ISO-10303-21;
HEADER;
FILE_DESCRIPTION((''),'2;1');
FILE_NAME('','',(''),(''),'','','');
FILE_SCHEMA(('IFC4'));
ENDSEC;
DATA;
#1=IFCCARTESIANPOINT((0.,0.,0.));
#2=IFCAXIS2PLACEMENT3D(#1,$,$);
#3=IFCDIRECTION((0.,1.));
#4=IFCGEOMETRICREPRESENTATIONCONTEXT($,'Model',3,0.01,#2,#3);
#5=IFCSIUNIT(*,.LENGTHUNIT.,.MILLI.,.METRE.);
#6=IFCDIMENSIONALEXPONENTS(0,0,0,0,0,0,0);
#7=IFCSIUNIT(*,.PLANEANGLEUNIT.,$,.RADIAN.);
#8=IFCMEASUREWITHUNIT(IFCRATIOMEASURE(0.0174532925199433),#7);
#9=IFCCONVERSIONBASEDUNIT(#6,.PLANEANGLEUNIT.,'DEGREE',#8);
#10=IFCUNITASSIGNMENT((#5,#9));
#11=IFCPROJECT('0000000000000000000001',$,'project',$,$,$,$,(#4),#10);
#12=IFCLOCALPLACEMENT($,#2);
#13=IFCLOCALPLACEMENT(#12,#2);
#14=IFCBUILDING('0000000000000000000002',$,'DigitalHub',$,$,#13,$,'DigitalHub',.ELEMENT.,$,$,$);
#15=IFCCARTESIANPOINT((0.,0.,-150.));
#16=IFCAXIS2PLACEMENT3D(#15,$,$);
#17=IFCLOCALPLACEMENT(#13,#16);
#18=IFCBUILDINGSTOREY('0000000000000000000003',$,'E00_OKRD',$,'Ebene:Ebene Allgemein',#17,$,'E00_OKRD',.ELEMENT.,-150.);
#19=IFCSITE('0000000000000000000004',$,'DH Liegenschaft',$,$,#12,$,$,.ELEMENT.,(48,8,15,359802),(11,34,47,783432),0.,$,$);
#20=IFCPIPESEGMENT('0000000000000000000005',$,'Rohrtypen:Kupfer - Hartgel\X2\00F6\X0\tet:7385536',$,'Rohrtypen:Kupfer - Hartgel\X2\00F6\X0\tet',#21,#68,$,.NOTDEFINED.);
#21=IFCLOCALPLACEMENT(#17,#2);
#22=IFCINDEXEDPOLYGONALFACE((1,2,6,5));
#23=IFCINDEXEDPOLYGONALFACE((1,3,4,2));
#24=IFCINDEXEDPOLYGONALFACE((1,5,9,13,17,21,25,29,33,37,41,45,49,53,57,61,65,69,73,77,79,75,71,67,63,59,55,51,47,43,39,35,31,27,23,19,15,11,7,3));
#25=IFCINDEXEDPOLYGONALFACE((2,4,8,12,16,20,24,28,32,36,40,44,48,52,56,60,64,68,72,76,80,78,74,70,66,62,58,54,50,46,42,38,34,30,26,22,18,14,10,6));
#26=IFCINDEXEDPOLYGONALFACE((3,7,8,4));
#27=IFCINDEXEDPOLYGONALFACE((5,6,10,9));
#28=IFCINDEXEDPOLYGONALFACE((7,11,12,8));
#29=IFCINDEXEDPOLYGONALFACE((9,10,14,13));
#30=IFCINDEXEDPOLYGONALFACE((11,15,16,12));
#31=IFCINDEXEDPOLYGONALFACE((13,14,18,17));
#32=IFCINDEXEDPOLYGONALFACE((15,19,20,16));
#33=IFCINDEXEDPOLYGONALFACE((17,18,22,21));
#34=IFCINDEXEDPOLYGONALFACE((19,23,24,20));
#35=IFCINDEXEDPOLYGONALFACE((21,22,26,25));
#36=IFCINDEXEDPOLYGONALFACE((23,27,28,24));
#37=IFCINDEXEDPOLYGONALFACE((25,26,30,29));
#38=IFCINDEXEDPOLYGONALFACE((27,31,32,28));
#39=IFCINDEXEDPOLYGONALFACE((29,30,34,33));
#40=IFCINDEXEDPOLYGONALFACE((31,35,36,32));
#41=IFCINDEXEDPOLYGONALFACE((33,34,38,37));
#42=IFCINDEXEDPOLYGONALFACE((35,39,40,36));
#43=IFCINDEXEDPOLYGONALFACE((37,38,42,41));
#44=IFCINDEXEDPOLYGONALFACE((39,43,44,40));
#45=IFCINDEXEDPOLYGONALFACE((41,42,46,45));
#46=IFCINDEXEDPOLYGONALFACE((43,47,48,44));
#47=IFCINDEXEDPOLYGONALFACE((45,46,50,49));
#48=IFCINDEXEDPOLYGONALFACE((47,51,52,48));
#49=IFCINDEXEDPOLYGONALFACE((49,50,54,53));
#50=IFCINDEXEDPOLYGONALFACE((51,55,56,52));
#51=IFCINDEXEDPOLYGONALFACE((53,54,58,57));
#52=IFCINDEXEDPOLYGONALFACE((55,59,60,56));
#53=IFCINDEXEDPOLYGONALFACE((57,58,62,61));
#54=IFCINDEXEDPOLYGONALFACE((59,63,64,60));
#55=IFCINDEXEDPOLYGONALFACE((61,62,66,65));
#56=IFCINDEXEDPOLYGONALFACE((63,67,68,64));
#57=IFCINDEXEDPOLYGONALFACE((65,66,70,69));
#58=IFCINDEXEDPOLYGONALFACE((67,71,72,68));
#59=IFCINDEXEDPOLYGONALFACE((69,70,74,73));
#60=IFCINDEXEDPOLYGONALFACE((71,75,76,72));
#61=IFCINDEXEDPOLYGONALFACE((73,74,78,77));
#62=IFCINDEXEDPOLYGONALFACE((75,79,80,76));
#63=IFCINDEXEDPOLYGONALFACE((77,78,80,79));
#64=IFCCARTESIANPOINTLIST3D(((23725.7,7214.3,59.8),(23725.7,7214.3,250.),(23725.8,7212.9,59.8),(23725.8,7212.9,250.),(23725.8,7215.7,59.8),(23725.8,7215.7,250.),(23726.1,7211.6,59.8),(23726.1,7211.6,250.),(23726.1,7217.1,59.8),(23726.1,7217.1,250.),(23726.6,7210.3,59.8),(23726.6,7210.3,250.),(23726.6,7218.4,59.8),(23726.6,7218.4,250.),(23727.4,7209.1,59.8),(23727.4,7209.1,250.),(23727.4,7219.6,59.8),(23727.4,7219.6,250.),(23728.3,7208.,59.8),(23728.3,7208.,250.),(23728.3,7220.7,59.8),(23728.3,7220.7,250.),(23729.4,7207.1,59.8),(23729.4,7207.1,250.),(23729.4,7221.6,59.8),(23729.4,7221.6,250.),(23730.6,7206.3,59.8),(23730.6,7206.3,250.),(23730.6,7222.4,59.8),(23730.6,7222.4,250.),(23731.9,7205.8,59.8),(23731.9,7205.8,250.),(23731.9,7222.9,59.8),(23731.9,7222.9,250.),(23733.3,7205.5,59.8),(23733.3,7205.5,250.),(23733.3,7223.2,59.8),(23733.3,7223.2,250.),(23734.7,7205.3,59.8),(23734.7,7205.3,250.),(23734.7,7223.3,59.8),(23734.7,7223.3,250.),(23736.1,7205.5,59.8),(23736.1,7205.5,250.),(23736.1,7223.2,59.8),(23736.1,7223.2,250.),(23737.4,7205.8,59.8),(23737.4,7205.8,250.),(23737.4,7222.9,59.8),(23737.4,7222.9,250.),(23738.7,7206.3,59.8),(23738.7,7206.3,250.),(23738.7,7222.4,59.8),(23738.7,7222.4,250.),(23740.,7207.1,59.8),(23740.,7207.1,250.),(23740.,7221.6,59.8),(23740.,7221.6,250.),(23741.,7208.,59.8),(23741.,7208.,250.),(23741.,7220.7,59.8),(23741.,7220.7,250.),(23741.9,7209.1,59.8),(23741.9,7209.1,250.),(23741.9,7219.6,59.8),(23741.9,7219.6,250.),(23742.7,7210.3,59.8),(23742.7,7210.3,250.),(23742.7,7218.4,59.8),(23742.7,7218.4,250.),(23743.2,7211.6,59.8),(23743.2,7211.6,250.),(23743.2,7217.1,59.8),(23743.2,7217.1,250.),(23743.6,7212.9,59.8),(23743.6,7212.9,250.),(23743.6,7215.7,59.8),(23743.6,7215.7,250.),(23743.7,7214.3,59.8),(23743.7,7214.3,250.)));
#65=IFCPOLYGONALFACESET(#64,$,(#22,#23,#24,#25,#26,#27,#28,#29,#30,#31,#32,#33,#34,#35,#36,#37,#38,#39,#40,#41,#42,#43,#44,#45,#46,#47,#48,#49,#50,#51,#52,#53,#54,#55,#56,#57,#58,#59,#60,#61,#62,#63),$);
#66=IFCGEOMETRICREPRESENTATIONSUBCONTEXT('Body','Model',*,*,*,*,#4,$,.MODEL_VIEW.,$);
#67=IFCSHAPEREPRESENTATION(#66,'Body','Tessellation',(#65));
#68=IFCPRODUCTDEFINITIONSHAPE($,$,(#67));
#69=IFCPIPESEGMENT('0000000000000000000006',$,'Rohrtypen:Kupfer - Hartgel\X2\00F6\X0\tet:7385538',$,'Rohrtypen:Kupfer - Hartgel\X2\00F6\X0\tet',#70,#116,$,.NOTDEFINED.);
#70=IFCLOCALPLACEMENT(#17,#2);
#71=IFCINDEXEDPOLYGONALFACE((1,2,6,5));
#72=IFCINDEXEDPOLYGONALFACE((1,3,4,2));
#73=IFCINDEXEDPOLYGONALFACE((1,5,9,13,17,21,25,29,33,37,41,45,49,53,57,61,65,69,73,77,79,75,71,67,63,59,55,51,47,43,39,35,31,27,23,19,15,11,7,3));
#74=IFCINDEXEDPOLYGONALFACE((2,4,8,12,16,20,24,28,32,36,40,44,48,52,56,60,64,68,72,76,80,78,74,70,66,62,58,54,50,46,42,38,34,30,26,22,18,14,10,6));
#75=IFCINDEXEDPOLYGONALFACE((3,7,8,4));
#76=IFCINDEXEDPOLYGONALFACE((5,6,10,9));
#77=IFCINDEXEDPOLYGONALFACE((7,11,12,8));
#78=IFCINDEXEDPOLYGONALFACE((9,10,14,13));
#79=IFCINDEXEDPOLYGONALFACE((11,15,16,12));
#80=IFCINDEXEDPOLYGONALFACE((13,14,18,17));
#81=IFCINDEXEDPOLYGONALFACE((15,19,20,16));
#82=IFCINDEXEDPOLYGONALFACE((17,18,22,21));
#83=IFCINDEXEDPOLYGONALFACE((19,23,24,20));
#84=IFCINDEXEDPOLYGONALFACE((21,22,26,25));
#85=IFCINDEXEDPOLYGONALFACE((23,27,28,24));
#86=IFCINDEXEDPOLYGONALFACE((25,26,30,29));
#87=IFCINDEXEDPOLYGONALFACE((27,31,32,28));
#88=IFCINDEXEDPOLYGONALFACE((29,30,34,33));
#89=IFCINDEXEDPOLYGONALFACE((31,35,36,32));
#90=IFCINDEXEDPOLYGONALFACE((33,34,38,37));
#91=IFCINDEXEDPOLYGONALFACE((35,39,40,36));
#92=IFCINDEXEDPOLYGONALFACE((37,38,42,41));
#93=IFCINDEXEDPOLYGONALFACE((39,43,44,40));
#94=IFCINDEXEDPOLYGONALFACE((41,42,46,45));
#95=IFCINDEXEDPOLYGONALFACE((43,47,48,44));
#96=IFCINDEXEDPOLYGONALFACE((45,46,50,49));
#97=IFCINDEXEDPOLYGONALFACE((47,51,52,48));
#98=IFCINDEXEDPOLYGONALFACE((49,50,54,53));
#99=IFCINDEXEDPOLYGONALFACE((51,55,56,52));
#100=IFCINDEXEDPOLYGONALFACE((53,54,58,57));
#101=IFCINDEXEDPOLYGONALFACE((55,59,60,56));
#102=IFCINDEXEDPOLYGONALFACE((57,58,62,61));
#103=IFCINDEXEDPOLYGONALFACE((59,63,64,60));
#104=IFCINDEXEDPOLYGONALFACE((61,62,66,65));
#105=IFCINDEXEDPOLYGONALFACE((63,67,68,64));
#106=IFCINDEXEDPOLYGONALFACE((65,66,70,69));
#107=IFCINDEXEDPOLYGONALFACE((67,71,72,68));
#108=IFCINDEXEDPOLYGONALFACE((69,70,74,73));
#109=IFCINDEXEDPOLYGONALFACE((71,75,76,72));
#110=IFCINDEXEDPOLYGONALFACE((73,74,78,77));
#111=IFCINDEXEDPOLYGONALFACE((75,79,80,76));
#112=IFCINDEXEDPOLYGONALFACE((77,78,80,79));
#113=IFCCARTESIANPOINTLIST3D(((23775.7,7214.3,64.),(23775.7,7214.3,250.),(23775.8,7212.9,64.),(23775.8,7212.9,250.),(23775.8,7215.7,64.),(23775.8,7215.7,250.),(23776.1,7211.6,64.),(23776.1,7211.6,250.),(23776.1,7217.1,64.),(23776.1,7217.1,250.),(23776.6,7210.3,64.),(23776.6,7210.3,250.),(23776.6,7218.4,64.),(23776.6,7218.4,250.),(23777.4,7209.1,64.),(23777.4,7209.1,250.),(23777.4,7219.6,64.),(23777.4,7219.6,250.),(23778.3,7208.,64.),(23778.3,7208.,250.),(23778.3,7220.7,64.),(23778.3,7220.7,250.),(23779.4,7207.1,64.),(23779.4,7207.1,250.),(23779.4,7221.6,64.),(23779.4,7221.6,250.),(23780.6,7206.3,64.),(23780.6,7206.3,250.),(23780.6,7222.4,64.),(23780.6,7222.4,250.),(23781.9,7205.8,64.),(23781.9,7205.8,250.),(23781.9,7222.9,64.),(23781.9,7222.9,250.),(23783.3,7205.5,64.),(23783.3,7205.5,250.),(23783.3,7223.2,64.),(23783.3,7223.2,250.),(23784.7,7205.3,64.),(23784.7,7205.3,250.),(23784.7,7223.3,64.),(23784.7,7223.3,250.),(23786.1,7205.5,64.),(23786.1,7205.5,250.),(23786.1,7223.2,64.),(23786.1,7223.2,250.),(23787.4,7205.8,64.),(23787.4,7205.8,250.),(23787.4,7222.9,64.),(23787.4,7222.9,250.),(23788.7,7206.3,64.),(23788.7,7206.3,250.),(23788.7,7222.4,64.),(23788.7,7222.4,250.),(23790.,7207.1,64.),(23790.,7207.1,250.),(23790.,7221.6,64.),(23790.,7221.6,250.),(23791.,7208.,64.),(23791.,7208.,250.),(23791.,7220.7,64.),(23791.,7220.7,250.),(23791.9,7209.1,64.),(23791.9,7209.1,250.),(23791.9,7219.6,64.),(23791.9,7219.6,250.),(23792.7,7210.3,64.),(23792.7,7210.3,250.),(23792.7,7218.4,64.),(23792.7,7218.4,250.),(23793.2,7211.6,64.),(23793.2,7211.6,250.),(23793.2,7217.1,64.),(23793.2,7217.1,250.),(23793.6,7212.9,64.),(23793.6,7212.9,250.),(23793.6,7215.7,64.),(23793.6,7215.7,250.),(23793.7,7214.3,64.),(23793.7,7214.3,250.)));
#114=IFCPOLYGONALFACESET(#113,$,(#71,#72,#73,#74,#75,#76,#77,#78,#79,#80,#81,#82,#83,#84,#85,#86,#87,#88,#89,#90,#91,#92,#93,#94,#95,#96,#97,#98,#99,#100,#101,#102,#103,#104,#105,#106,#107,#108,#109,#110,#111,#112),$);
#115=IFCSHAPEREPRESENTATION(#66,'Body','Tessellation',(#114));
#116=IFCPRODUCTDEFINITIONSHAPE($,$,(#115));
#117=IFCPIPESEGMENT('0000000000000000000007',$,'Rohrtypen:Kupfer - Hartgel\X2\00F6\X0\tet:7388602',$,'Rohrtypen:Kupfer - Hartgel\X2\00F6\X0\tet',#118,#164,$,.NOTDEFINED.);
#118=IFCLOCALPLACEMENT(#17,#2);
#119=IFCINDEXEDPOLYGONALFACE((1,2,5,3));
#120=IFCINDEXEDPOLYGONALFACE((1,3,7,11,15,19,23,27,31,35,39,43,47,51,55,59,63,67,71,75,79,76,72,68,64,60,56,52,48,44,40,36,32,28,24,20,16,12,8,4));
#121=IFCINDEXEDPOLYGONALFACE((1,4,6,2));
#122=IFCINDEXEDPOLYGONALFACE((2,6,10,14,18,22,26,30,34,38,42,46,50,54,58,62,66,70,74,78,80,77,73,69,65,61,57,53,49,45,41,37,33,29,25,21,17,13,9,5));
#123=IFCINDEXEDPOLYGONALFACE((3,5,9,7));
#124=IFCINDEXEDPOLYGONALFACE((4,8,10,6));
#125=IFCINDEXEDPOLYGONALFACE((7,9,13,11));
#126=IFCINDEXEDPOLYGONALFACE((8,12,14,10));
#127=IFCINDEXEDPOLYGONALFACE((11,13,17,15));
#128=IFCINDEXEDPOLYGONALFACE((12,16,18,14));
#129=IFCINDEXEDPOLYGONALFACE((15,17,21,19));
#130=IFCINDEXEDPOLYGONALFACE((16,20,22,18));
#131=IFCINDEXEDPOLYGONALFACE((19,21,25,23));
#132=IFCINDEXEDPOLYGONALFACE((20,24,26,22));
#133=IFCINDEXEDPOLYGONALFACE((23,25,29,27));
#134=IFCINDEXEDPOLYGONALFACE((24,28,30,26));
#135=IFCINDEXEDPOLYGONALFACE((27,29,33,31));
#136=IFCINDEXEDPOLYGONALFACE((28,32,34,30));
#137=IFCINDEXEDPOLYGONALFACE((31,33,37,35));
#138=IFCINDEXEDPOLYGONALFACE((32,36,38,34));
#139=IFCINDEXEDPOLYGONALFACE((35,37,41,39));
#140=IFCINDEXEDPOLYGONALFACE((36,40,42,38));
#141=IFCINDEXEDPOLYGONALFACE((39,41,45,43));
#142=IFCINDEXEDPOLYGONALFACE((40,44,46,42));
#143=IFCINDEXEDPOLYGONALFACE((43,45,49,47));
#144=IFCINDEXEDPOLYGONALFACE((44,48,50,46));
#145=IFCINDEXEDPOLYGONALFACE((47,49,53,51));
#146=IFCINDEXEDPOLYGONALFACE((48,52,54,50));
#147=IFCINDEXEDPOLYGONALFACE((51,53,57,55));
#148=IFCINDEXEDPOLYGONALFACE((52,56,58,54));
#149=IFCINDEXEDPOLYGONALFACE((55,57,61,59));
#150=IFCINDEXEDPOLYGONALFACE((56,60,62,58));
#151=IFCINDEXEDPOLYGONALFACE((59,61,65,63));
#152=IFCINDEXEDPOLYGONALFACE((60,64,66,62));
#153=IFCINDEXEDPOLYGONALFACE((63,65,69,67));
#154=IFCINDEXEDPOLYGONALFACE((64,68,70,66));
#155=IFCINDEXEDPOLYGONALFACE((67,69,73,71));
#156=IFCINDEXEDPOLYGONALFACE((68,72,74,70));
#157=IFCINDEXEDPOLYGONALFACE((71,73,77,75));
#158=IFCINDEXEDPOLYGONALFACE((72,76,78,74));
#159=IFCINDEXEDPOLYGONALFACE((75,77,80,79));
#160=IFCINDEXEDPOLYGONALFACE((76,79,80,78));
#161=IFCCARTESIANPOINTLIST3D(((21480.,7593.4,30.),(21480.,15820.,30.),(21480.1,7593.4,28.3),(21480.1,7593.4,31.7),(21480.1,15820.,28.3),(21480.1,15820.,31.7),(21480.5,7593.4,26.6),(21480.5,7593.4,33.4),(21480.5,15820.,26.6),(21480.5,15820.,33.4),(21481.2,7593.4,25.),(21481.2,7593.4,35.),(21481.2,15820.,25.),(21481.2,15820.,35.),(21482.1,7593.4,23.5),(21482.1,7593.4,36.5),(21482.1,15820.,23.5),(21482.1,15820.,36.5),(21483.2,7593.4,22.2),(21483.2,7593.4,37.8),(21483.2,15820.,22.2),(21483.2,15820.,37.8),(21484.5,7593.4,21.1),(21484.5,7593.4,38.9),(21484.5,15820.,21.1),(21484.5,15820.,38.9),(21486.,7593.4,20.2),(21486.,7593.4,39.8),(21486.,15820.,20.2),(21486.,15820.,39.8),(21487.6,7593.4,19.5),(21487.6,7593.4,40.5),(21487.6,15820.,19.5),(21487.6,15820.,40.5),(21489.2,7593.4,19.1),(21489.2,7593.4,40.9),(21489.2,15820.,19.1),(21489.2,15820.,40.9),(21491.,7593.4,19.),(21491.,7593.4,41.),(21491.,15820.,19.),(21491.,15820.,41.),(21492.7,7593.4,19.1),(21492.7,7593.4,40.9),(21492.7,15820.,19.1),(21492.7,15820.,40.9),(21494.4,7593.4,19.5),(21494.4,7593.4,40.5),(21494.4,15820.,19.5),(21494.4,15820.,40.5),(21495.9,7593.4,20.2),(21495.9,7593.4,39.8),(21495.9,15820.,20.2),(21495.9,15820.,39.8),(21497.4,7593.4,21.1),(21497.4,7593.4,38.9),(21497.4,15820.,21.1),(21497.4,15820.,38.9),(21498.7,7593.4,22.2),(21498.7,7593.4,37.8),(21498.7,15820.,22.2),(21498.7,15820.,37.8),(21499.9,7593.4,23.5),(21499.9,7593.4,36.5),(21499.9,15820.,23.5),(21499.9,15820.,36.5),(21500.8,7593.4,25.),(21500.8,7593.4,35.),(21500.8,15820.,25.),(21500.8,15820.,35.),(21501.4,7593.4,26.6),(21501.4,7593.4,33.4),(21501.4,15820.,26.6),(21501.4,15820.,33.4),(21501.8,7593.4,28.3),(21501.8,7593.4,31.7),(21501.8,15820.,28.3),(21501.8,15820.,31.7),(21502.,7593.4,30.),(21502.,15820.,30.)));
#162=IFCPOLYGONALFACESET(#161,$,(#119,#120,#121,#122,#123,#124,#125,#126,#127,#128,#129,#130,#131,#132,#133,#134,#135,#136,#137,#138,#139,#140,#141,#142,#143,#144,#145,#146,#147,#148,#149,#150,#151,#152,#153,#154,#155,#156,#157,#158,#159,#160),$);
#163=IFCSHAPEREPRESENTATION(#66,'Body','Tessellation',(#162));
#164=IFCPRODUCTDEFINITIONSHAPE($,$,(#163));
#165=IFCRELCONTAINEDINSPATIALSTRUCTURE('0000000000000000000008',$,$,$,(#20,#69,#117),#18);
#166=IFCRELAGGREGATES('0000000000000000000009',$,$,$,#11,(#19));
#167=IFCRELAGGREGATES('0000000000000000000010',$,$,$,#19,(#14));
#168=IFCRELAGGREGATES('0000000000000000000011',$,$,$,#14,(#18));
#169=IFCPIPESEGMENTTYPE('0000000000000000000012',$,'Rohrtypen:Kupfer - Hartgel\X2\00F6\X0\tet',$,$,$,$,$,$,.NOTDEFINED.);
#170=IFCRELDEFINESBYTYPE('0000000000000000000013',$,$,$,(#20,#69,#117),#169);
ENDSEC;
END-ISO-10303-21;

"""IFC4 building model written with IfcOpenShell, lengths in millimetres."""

from ifc_helpers import new_model, entity, si_unit, converted_unit, direction, frame, origin, place, context, subcontext, project, spatial, indexed_curve, outline, extrude, type_object, element, save


model = new_model("IFC4")

# Units and contexts
model_context = context("Model", 3, precision=0.01, world=origin(), true_north=direction((0.0, 1.0)))
body_context = subcontext(model_context, "Body", "Model", "MODEL_VIEW")
ifc_project = project(units=[si_unit("LENGTHUNIT", "METRE", prefix="MILLI"), converted_unit("PLANEANGLEUNIT", "DEGREE", entity("IfcRatioMeasure", 0.0174532925199433), si_unit("PLANEANGLEUNIT", "RADIAN"), dimensions=[0, 0, 0, 0, 0, 0, 0])], contexts=[model_context])

# Site, building, storey
site_placement = place(None, origin())
site = spatial("IfcSite", under=ifc_project, at=site_placement, Name="DH Liegenschaft", CompositionType="ELEMENT", RefLatitude=(48, 8, 15, 359802), RefLongitude=(11, 34, 47, 783432), RefElevation=0.0)
building_placement = place(site_placement, origin())
building = spatial("IfcBuilding", under=site, at=building_placement, Name="DigitalHub", LongName="DigitalHub", CompositionType="ELEMENT")
storey_placement = place(building_placement, frame((0.0, 0.0, -150.0)))
storey = spatial("IfcBuildingStorey", under=building, at=storey_placement, Name="E00_OKRD", ObjectType="Ebene:Ebene Allgemein", LongName="E00_OKRD", CompositionType="ELEMENT", Elevation=-150.0)

# Pipe segments
pipe_segment_type = type_object("IfcPipeSegmentType", Name="Rohrtypen:Kupfer - Hartgelötet", PredefinedType="NOTDEFINED")
pipe_segment_1_placement = place(storey_placement, frame((23724.1, 7203.7, 59.8)))
element("IfcPipeSegment", 1, at=pipe_segment_1_placement, inside=storey, type_object=pipe_segment_type, Name="Rohrtypen:Kupfer - Hartgelötet:7385536", ObjectType="Rohrtypen:Kupfer - Hartgelötet", PredefinedType="NOTDEFINED", context=body_context, shape_type="SweptSolid", body=[
    extrude(outline(indexed_curve([(9.0, 0.0), (8.9, 1.4), (8.6, 2.8), (8.0, 4.1), (7.3, 5.3), (6.4, 6.4), (5.3, 7.3), (4.1, 8.0), (2.8, 8.6), (1.4, 8.9), (0.0, 9.0), (-1.4, 8.9), (-2.8, 8.6), (-4.1, 8.0), (-5.3, 7.3), (-6.4, 6.4), (-7.3, 5.3), (-8.0, 4.1), (-8.6, 2.8), (-8.9, 1.4), (-9.0, 0.0), (-8.9, -1.4), (-8.6, -2.8), (-8.0, -4.1), (-7.3, -5.3), (-6.4, -6.4), (-5.3, -7.3), (-4.1, -8.0), (-2.8, -8.6), (-1.4, -8.9), (0.0, -9.0), (1.4, -8.9), (2.8, -8.6), (4.1, -8.0), (5.3, -7.3), (6.4, -6.4), (7.3, -5.3), (8.0, -4.1), (8.6, -2.8), (8.9, -1.4), (9.0, 0.0)], self_intersect=False)), frame((10.6, 10.6, 0.0)), (0.0, 0.0, 1.0), 190.2),
])
pipe_segment_2_placement = place(storey_placement, frame((23774.1, 7203.7, 64.0)))
element("IfcPipeSegment", 2, at=pipe_segment_2_placement, inside=storey, type_object=pipe_segment_type, Name="Rohrtypen:Kupfer - Hartgelötet:7385538", ObjectType="Rohrtypen:Kupfer - Hartgelötet", PredefinedType="NOTDEFINED", context=body_context, shape_type="SweptSolid", body=[
    extrude(outline(indexed_curve([(9.0, 0.0), (8.9, 1.4), (8.6, 2.8), (8.0, 4.1), (7.3, 5.3), (6.4, 6.4), (5.3, 7.3), (4.1, 8.0), (2.8, 8.6), (1.4, 8.9), (0.0, 9.0), (-1.4, 8.9), (-2.8, 8.6), (-4.1, 8.0), (-5.3, 7.3), (-6.4, 6.4), (-7.3, 5.3), (-8.0, 4.1), (-8.6, 2.8), (-8.9, 1.4), (-9.0, 0.0), (-8.9, -1.4), (-8.6, -2.8), (-8.0, -4.1), (-7.3, -5.3), (-6.4, -6.4), (-5.3, -7.3), (-4.1, -8.0), (-2.8, -8.6), (-1.4, -8.9), (0.0, -9.0), (1.4, -8.9), (2.8, -8.6), (4.1, -8.0), (5.3, -7.3), (6.4, -6.4), (7.3, -5.3), (8.0, -4.1), (8.6, -2.8), (8.9, -1.4), (9.0, 0.0)], self_intersect=False)), frame((10.6, 10.6, 0.0)), (0.0, 0.0, 1.0), 186.0),
])
pipe_segment_3_placement = place(storey_placement, frame((21478.4, 7593.4, 17.4)))
element("IfcPipeSegment", 3, at=pipe_segment_3_placement, inside=storey, type_object=pipe_segment_type, Name="Rohrtypen:Kupfer - Hartgelötet:7388602", ObjectType="Rohrtypen:Kupfer - Hartgelötet", PredefinedType="NOTDEFINED", context=body_context, shape_type="SweptSolid", body=[
    extrude(outline(indexed_curve([(11.0, 0.0), (10.9, 1.7), (10.5, 3.4), (9.8, 5.0), (8.9, 6.5), (7.8, 7.8), (6.5, 8.9), (5.0, 9.8), (3.4, 10.5), (1.7, 10.9), (0.0, 11.0), (-1.7, 10.9), (-3.4, 10.5), (-5.0, 9.8), (-6.5, 8.9), (-7.8, 7.8), (-8.9, 6.5), (-9.8, 5.0), (-10.5, 3.4), (-10.9, 1.7), (-11.0, 0.0), (-10.9, -1.7), (-10.5, -3.4), (-9.8, -5.0), (-8.9, -6.5), (-7.8, -7.8), (-6.5, -8.9), (-5.0, -9.8), (-3.4, -10.5), (-1.7, -10.9), (0.0, -11.0), (1.7, -10.9), (3.4, -10.5), (5.0, -9.8), (6.5, -8.9), (7.8, -7.8), (8.9, -6.5), (9.8, -5.0), (10.5, -3.4), (10.9, -1.7), (11.0, 0.0)], self_intersect=False)), frame((12.6, 0.0, 12.6), z_axis=(0.0, 1.0, 0.0), x_axis=(1.0, 0.0, 0.0)), (0.0, 0.0, 1.0), 8226.7),
])

save(model, "model.ifc")
